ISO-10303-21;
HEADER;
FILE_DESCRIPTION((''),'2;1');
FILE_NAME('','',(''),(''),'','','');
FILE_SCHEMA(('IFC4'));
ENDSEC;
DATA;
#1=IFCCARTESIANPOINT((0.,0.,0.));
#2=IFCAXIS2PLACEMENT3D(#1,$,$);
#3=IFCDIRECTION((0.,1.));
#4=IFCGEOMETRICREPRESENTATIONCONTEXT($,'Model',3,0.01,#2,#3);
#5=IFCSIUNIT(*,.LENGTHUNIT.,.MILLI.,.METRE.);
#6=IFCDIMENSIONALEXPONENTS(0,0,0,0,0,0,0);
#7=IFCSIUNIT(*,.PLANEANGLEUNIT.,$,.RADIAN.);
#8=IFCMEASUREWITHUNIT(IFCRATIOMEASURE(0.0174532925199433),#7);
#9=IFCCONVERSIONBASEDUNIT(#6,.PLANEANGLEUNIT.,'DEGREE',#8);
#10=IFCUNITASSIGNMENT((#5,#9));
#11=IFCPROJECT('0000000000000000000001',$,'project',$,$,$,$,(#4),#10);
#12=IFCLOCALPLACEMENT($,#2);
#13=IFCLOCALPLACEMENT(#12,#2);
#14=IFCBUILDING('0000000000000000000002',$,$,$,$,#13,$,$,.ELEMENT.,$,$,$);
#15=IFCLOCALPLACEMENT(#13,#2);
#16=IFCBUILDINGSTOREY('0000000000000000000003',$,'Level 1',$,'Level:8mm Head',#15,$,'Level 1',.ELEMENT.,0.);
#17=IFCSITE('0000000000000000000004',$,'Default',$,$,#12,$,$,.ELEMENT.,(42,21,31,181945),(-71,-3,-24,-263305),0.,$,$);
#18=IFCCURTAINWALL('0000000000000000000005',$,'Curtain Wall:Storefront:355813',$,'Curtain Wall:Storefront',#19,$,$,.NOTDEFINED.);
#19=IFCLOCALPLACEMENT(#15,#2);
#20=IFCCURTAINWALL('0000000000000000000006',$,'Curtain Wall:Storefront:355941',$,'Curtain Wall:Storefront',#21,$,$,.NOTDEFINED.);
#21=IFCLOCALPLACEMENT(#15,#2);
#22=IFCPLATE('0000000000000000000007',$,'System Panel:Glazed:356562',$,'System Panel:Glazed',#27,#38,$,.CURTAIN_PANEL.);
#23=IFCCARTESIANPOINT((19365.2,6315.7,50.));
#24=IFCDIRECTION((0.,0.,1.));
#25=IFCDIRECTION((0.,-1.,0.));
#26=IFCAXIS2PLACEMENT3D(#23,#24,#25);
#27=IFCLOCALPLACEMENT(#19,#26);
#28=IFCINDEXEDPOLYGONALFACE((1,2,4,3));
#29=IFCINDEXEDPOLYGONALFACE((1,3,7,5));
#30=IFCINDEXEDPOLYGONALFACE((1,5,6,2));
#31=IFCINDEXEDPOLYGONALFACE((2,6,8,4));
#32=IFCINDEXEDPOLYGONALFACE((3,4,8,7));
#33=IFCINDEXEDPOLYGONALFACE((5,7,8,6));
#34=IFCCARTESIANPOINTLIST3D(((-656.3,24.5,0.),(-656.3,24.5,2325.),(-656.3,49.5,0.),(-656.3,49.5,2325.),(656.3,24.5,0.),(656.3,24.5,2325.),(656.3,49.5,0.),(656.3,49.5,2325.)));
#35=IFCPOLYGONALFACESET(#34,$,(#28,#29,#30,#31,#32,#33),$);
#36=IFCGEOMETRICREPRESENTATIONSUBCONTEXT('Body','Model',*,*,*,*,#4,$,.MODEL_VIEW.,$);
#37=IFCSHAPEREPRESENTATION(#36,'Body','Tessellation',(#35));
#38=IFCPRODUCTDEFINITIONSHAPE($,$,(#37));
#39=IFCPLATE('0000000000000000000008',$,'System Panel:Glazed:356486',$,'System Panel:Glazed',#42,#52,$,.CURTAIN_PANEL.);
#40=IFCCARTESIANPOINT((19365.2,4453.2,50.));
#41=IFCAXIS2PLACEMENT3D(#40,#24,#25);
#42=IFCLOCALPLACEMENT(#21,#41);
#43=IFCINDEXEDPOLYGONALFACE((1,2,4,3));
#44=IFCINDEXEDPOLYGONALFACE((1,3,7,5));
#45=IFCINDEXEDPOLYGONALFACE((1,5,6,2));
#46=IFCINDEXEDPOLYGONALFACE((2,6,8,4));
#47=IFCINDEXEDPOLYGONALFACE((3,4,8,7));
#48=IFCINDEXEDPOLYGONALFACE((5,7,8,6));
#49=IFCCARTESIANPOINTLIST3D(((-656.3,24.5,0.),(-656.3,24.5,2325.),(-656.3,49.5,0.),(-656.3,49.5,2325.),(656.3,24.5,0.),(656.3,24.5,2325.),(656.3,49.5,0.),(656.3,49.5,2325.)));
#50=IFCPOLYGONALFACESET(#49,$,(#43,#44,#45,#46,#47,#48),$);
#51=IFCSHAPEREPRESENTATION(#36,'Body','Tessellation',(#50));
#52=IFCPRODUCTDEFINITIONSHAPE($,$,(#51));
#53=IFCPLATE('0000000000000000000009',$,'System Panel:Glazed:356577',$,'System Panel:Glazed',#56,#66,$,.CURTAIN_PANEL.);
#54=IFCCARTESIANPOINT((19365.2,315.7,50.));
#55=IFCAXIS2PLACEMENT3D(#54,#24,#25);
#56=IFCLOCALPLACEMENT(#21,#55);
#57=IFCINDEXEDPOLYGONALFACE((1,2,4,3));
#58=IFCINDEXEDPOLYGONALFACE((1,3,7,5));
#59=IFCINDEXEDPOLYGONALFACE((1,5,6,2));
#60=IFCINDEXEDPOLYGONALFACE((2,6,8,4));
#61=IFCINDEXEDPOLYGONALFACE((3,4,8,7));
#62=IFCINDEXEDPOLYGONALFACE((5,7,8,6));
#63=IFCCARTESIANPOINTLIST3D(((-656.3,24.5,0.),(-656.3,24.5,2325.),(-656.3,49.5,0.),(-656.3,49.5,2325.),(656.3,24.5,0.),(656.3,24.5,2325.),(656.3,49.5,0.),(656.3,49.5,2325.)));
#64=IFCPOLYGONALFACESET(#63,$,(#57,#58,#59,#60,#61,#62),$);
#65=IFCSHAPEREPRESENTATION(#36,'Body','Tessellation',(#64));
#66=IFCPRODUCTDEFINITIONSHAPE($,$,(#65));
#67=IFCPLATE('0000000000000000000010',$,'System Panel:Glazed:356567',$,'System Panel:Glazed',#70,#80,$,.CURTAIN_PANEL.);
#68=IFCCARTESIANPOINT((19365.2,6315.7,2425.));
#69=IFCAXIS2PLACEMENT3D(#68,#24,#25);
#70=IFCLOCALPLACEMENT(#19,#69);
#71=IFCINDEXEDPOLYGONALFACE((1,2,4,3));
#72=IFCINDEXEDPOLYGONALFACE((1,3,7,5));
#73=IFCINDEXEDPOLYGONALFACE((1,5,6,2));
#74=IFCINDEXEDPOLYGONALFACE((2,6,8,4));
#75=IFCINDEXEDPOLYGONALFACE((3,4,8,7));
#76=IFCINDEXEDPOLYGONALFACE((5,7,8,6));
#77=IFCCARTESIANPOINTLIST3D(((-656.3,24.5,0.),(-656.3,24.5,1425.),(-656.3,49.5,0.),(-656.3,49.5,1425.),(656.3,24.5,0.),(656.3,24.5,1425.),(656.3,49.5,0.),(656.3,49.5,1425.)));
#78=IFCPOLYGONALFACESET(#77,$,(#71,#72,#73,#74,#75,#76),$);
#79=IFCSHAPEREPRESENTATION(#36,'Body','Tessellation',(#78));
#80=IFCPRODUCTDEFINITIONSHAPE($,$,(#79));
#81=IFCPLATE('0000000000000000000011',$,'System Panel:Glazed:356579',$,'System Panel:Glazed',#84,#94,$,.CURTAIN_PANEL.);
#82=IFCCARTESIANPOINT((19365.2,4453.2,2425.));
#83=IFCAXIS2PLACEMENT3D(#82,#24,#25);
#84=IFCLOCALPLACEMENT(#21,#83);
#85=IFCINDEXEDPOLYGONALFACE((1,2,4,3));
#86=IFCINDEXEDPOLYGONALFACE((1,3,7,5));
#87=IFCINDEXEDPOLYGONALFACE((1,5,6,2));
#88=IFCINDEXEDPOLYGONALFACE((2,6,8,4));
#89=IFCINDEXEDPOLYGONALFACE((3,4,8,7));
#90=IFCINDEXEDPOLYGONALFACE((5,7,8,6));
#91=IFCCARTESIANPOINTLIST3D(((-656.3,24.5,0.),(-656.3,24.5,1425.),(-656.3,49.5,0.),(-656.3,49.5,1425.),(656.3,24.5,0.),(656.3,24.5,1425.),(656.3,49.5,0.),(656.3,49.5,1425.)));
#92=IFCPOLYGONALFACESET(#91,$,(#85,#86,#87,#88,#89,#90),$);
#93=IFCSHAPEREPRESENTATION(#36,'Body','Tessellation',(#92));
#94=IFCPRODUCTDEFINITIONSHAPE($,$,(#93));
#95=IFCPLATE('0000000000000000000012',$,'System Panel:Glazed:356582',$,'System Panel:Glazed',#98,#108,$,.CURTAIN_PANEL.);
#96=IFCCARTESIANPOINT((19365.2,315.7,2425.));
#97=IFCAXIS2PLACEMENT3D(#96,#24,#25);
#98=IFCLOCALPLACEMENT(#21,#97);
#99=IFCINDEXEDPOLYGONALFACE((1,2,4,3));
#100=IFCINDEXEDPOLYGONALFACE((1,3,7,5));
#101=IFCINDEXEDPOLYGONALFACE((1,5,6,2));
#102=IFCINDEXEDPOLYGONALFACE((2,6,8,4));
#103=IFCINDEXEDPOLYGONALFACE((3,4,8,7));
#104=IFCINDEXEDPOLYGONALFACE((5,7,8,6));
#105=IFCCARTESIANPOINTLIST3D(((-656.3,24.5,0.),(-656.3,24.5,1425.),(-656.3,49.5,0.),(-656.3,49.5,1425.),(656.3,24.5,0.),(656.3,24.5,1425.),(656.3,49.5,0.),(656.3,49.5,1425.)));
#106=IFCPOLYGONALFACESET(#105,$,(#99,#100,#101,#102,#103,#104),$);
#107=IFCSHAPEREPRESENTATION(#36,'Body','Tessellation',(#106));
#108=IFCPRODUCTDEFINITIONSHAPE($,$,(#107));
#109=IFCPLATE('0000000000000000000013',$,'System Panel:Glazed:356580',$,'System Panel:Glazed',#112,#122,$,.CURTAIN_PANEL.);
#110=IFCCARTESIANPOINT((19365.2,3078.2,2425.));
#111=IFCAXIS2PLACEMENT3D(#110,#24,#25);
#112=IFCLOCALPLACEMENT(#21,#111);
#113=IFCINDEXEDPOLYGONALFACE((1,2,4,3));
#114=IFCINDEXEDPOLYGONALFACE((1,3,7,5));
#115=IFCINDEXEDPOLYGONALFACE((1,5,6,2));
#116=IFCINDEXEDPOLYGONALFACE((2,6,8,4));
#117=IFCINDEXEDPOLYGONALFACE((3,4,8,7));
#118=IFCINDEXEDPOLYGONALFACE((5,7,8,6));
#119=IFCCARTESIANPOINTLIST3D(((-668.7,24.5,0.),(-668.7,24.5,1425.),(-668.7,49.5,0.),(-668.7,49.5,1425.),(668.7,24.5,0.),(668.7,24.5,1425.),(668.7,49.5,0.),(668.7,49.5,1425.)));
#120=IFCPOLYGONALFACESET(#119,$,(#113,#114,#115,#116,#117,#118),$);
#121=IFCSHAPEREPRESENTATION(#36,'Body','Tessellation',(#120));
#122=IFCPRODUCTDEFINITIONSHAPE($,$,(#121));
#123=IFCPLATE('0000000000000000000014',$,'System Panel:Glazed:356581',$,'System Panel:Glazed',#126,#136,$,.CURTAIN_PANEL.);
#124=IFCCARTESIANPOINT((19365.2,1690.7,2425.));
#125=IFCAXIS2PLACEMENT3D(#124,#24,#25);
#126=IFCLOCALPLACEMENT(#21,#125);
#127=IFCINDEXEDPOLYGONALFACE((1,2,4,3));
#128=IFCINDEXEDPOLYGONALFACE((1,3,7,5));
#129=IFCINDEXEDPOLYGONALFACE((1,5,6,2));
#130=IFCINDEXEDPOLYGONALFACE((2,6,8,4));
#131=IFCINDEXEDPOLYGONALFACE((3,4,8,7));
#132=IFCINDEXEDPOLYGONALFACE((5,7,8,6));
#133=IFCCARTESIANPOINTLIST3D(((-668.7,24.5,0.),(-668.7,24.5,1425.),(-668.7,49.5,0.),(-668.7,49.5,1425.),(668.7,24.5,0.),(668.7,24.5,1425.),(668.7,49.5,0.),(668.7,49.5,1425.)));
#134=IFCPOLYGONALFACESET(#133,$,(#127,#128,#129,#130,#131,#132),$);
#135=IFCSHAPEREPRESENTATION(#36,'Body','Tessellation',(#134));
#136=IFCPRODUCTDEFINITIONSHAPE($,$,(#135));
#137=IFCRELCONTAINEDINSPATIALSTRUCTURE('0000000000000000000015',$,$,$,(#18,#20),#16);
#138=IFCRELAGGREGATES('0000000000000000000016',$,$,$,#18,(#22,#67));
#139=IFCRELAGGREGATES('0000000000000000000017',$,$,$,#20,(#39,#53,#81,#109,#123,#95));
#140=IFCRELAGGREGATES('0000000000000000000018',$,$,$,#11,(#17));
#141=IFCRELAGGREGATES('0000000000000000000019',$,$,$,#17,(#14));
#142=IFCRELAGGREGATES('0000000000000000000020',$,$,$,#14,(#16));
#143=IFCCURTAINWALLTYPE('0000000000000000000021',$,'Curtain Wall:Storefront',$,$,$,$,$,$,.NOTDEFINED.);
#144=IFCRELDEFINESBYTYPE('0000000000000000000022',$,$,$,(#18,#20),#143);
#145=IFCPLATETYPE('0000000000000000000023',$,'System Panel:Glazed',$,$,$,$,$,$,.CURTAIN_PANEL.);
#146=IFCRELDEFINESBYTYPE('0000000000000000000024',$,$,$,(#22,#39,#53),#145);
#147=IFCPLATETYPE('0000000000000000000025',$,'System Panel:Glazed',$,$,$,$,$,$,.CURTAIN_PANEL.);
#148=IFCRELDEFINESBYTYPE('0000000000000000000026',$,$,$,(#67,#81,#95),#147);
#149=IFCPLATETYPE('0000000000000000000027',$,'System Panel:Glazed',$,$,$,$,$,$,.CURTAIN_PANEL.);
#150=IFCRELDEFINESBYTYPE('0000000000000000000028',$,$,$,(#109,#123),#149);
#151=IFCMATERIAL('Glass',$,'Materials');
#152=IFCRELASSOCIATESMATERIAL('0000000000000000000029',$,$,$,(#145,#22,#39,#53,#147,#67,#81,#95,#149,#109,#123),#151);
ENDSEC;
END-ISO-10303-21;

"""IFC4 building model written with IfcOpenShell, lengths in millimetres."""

from ifc_helpers import new_model, entity, si_unit, converted_unit, direction, frame, origin, place, context, subcontext, project, spatial, indexed_curve, outline, extrude, shape, source, transform, mapped, material, type_object, type_shapes, element, aggregate, save


model = new_model("IFC4")

# Units and contexts
model_context = context("Model", 3, precision=0.01, world=origin(), true_north=direction((0.0, 1.0)))
body_context = subcontext(model_context, "Body", "Model", "MODEL_VIEW")
footprint_context = subcontext(model_context, "FootPrint", "Model", "MODEL_VIEW")
ifc_project = project(units=[si_unit("LENGTHUNIT", "METRE", prefix="MILLI"), converted_unit("PLANEANGLEUNIT", "DEGREE", entity("IfcRatioMeasure", 0.0174532925199433), si_unit("PLANEANGLEUNIT", "RADIAN"), dimensions=[0, 0, 0, 0, 0, 0, 0])], contexts=[model_context])

# Site, building, storey
site_placement = place(None, origin())
site = spatial("IfcSite", under=ifc_project, at=site_placement, Name="Default", CompositionType="ELEMENT", RefLatitude=(42, 21, 31, 181945), RefLongitude=(-71, -3, -24, -263305), RefElevation=0.0)
building_placement = place(site_placement, origin())
building = spatial("IfcBuilding", under=site, at=building_placement, CompositionType="ELEMENT")
storey_placement = place(building_placement, origin())
storey = spatial("IfcBuildingStorey", under=building, at=storey_placement, Name="Level 1", ObjectType="Level:8mm Head", LongName="Level 1", CompositionType="ELEMENT", Elevation=0.0)

# Curtain walls
curtain_wall_type_1 = type_object("IfcCurtainWallType", Name="Curtain Wall:Storefront", PredefinedType="NOTDEFINED")
curtain_wall_1_placement = place(storey_placement, origin())
curtain_wall_1 = element("IfcCurtainWall", 1, at=curtain_wall_1_placement, inside=storey, type_object=curtain_wall_type_1, Name="Curtain Wall:Storefront:355813", ObjectType="Curtain Wall:Storefront", PredefinedType="NOTDEFINED")
curtain_wall_2_placement = place(storey_placement, origin())
curtain_wall_2 = element("IfcCurtainWall", 2, at=curtain_wall_2_placement, inside=storey, type_object=curtain_wall_type_1, Name="Curtain Wall:Storefront:355941", ObjectType="Curtain Wall:Storefront", PredefinedType="NOTDEFINED")

# Plates
ifc_material_1 = material(Name="Glass", Category="Materials")
plate_type_1 = type_object("IfcPlateType", Name="System Panel:Glazed", PredefinedType="CURTAIN_PANEL", material=ifc_material_1)
shared_shape_1 = source(origin(), body_context, "Body", "SweptSolid", [
    extrude(outline(indexed_curve([(-12.5, -656.3), (12.5, -656.3), (12.5, 656.3), (-12.5, 656.3), (-12.5, -656.3)], self_intersect=False)), frame((0.0, 37.0, 0.0), z_axis=(0.0, 0.0, 1.0), x_axis=(0.0, 1.0, 0.0)), (0.0, 0.0, 1.0), 2325.0),
])
shared_shape_2 = source(origin(), footprint_context, "FootPrint", "Curve2D", [
    entity("IfcIndexedPolyCurve", entity("IfcCartesianPointList2D", [[656.3, 24.5], [656.3, 49.5], [-656.3, 49.5], [-656.3, 24.5], [656.3, 24.5]]), None, False),
])
type_shapes(plate_type_1, [shared_shape_1, shared_shape_2])
plate_1_placement = place(curtain_wall_1_placement, frame((19365.2, 6315.7, 50.0), z_axis=(0.0, 0.0, 1.0), x_axis=(0.0, -1.0, 0.0)))
plate_1 = element("IfcPlate", 3, at=plate_1_placement, type_object=plate_type_1, material=ifc_material_1, Name="System Panel:Glazed:356562", ObjectType="System Panel:Glazed", PredefinedType="CURTAIN_PANEL", shapes=[
    shape(body_context, "Body", "MappedRepresentation", [mapped(shared_shape_1, transform((0.0, 0.0, 0.0), scale=1.0))]),
    shape(body_context, "Body", "MappedRepresentation", [mapped(shared_shape_2, transform((0.0, 0.0, 0.0), scale=1.0))]),
])
plate_2_placement = place(curtain_wall_2_placement, frame((19365.2, 4453.2, 50.0), z_axis=(0.0, 0.0, 1.0), x_axis=(0.0, -1.0, 0.0)))
plate_2 = element("IfcPlate", 4, at=plate_2_placement, type_object=plate_type_1, material=ifc_material_1, Name="System Panel:Glazed:356486", ObjectType="System Panel:Glazed", PredefinedType="CURTAIN_PANEL", shapes=[
    shape(body_context, "Body", "MappedRepresentation", [mapped(shared_shape_1, transform((0.0, 0.0, 0.0), scale=1.0))]),
    shape(body_context, "Body", "MappedRepresentation", [mapped(shared_shape_2, transform((0.0, 0.0, 0.0), scale=1.0))]),
])
plate_3_placement = place(curtain_wall_2_placement, frame((19365.2, 315.7, 50.0), z_axis=(0.0, 0.0, 1.0), x_axis=(0.0, -1.0, 0.0)))
plate_3 = element("IfcPlate", 5, at=plate_3_placement, type_object=plate_type_1, material=ifc_material_1, Name="System Panel:Glazed:356577", ObjectType="System Panel:Glazed", PredefinedType="CURTAIN_PANEL", shapes=[
    shape(body_context, "Body", "MappedRepresentation", [mapped(shared_shape_1, transform((0.0, 0.0, 0.0), scale=1.0))]),
    shape(body_context, "Body", "MappedRepresentation", [mapped(shared_shape_2, transform((0.0, 0.0, 0.0), scale=1.0))]),
])
plate_type_2 = type_object("IfcPlateType", Name="System Panel:Glazed", PredefinedType="CURTAIN_PANEL", material=ifc_material_1)
shared_shape_3 = source(origin(), body_context, "Body", "SweptSolid", [
    extrude(outline(indexed_curve([(-12.5, -656.3), (12.5, -656.3), (12.5, 656.3), (-12.5, 656.3), (-12.5, -656.3)], self_intersect=False)), frame((0.0, 37.0, 0.0), z_axis=(0.0, 0.0, 1.0), x_axis=(0.0, 1.0, 0.0)), (0.0, 0.0, 1.0), 1425.0),
])
shared_shape_4 = source(origin(), footprint_context, "FootPrint", "Curve2D", [
    entity("IfcIndexedPolyCurve", entity("IfcCartesianPointList2D", [[656.3, 24.5], [656.3, 49.5], [-656.3, 49.5], [-656.3, 24.5], [656.3, 24.5]]), None, False),
])
type_shapes(plate_type_2, [shared_shape_3, shared_shape_4])
plate_4_placement = place(curtain_wall_1_placement, frame((19365.2, 6315.7, 2425.0), z_axis=(0.0, 0.0, 1.0), x_axis=(0.0, -1.0, 0.0)))
plate_4 = element("IfcPlate", 6, at=plate_4_placement, type_object=plate_type_2, material=ifc_material_1, Name="System Panel:Glazed:356567", ObjectType="System Panel:Glazed", PredefinedType="CURTAIN_PANEL", shapes=[
    shape(body_context, "Body", "MappedRepresentation", [mapped(shared_shape_3, transform((0.0, 0.0, 0.0), scale=1.0))]),
    shape(body_context, "Body", "MappedRepresentation", [mapped(shared_shape_4, transform((0.0, 0.0, 0.0), scale=1.0))]),
])
aggregate(curtain_wall_1, [plate_1, plate_4])
plate_5_placement = place(curtain_wall_2_placement, frame((19365.2, 4453.2, 2425.0), z_axis=(0.0, 0.0, 1.0), x_axis=(0.0, -1.0, 0.0)))
plate_5 = element("IfcPlate", 7, at=plate_5_placement, type_object=plate_type_2, material=ifc_material_1, Name="System Panel:Glazed:356579", ObjectType="System Panel:Glazed", PredefinedType="CURTAIN_PANEL", shapes=[
    shape(body_context, "Body", "MappedRepresentation", [mapped(shared_shape_3, transform((0.0, 0.0, 0.0), scale=1.0))]),
    shape(body_context, "Body", "MappedRepresentation", [mapped(shared_shape_4, transform((0.0, 0.0, 0.0), scale=1.0))]),
])
plate_6_placement = place(curtain_wall_2_placement, frame((19365.2, 315.7, 2425.0), z_axis=(0.0, 0.0, 1.0), x_axis=(0.0, -1.0, 0.0)))
plate_6 = element("IfcPlate", 8, at=plate_6_placement, type_object=plate_type_2, material=ifc_material_1, Name="System Panel:Glazed:356582", ObjectType="System Panel:Glazed", PredefinedType="CURTAIN_PANEL", shapes=[
    shape(body_context, "Body", "MappedRepresentation", [mapped(shared_shape_3, transform((0.0, 0.0, 0.0), scale=1.0))]),
    shape(body_context, "Body", "MappedRepresentation", [mapped(shared_shape_4, transform((0.0, 0.0, 0.0), scale=1.0))]),
])
plate_type_3 = type_object("IfcPlateType", Name="System Panel:Glazed", PredefinedType="CURTAIN_PANEL", material=ifc_material_1)
shared_shape_5 = source(origin(), body_context, "Body", "SweptSolid", [
    extrude(outline(indexed_curve([(-12.5, -668.7), (12.5, -668.7), (12.5, 668.7), (-12.5, 668.7), (-12.5, -668.7)], self_intersect=False)), frame((0.0, 37.0, 0.0), z_axis=(0.0, 0.0, 1.0), x_axis=(0.0, 1.0, 0.0)), (0.0, 0.0, 1.0), 1425.0),
])
shared_shape_6 = source(origin(), footprint_context, "FootPrint", "Curve2D", [
    entity("IfcIndexedPolyCurve", entity("IfcCartesianPointList2D", [[668.7, 24.5], [668.7, 49.5], [-668.7, 49.5], [-668.7, 24.5], [668.7, 24.5]]), None, False),
])
type_shapes(plate_type_3, [shared_shape_5, shared_shape_6])
plate_7_placement = place(curtain_wall_2_placement, frame((19365.2, 3078.2, 2425.0), z_axis=(0.0, 0.0, 1.0), x_axis=(0.0, -1.0, 0.0)))
plate_7 = element("IfcPlate", 9, at=plate_7_placement, type_object=plate_type_3, material=ifc_material_1, Name="System Panel:Glazed:356580", ObjectType="System Panel:Glazed", PredefinedType="CURTAIN_PANEL", shapes=[
    shape(body_context, "Body", "MappedRepresentation", [mapped(shared_shape_5, transform((0.0, 0.0, 0.0), scale=1.0))]),
    shape(body_context, "Body", "MappedRepresentation", [mapped(shared_shape_6, transform((0.0, 0.0, 0.0), scale=1.0))]),
])
plate_8_placement = place(curtain_wall_2_placement, frame((19365.2, 1690.7, 2425.0), z_axis=(0.0, 0.0, 1.0), x_axis=(0.0, -1.0, 0.0)))
plate_8 = element("IfcPlate", 10, at=plate_8_placement, type_object=plate_type_3, material=ifc_material_1, Name="System Panel:Glazed:356581", ObjectType="System Panel:Glazed", PredefinedType="CURTAIN_PANEL", shapes=[
    shape(body_context, "Body", "MappedRepresentation", [mapped(shared_shape_5, transform((0.0, 0.0, 0.0), scale=1.0))]),
    shape(body_context, "Body", "MappedRepresentation", [mapped(shared_shape_6, transform((0.0, 0.0, 0.0), scale=1.0))]),
])

aggregate(curtain_wall_2, [plate_2, plate_3, plate_5, plate_7, plate_8, plate_6])

save(model, "model.ifc")
